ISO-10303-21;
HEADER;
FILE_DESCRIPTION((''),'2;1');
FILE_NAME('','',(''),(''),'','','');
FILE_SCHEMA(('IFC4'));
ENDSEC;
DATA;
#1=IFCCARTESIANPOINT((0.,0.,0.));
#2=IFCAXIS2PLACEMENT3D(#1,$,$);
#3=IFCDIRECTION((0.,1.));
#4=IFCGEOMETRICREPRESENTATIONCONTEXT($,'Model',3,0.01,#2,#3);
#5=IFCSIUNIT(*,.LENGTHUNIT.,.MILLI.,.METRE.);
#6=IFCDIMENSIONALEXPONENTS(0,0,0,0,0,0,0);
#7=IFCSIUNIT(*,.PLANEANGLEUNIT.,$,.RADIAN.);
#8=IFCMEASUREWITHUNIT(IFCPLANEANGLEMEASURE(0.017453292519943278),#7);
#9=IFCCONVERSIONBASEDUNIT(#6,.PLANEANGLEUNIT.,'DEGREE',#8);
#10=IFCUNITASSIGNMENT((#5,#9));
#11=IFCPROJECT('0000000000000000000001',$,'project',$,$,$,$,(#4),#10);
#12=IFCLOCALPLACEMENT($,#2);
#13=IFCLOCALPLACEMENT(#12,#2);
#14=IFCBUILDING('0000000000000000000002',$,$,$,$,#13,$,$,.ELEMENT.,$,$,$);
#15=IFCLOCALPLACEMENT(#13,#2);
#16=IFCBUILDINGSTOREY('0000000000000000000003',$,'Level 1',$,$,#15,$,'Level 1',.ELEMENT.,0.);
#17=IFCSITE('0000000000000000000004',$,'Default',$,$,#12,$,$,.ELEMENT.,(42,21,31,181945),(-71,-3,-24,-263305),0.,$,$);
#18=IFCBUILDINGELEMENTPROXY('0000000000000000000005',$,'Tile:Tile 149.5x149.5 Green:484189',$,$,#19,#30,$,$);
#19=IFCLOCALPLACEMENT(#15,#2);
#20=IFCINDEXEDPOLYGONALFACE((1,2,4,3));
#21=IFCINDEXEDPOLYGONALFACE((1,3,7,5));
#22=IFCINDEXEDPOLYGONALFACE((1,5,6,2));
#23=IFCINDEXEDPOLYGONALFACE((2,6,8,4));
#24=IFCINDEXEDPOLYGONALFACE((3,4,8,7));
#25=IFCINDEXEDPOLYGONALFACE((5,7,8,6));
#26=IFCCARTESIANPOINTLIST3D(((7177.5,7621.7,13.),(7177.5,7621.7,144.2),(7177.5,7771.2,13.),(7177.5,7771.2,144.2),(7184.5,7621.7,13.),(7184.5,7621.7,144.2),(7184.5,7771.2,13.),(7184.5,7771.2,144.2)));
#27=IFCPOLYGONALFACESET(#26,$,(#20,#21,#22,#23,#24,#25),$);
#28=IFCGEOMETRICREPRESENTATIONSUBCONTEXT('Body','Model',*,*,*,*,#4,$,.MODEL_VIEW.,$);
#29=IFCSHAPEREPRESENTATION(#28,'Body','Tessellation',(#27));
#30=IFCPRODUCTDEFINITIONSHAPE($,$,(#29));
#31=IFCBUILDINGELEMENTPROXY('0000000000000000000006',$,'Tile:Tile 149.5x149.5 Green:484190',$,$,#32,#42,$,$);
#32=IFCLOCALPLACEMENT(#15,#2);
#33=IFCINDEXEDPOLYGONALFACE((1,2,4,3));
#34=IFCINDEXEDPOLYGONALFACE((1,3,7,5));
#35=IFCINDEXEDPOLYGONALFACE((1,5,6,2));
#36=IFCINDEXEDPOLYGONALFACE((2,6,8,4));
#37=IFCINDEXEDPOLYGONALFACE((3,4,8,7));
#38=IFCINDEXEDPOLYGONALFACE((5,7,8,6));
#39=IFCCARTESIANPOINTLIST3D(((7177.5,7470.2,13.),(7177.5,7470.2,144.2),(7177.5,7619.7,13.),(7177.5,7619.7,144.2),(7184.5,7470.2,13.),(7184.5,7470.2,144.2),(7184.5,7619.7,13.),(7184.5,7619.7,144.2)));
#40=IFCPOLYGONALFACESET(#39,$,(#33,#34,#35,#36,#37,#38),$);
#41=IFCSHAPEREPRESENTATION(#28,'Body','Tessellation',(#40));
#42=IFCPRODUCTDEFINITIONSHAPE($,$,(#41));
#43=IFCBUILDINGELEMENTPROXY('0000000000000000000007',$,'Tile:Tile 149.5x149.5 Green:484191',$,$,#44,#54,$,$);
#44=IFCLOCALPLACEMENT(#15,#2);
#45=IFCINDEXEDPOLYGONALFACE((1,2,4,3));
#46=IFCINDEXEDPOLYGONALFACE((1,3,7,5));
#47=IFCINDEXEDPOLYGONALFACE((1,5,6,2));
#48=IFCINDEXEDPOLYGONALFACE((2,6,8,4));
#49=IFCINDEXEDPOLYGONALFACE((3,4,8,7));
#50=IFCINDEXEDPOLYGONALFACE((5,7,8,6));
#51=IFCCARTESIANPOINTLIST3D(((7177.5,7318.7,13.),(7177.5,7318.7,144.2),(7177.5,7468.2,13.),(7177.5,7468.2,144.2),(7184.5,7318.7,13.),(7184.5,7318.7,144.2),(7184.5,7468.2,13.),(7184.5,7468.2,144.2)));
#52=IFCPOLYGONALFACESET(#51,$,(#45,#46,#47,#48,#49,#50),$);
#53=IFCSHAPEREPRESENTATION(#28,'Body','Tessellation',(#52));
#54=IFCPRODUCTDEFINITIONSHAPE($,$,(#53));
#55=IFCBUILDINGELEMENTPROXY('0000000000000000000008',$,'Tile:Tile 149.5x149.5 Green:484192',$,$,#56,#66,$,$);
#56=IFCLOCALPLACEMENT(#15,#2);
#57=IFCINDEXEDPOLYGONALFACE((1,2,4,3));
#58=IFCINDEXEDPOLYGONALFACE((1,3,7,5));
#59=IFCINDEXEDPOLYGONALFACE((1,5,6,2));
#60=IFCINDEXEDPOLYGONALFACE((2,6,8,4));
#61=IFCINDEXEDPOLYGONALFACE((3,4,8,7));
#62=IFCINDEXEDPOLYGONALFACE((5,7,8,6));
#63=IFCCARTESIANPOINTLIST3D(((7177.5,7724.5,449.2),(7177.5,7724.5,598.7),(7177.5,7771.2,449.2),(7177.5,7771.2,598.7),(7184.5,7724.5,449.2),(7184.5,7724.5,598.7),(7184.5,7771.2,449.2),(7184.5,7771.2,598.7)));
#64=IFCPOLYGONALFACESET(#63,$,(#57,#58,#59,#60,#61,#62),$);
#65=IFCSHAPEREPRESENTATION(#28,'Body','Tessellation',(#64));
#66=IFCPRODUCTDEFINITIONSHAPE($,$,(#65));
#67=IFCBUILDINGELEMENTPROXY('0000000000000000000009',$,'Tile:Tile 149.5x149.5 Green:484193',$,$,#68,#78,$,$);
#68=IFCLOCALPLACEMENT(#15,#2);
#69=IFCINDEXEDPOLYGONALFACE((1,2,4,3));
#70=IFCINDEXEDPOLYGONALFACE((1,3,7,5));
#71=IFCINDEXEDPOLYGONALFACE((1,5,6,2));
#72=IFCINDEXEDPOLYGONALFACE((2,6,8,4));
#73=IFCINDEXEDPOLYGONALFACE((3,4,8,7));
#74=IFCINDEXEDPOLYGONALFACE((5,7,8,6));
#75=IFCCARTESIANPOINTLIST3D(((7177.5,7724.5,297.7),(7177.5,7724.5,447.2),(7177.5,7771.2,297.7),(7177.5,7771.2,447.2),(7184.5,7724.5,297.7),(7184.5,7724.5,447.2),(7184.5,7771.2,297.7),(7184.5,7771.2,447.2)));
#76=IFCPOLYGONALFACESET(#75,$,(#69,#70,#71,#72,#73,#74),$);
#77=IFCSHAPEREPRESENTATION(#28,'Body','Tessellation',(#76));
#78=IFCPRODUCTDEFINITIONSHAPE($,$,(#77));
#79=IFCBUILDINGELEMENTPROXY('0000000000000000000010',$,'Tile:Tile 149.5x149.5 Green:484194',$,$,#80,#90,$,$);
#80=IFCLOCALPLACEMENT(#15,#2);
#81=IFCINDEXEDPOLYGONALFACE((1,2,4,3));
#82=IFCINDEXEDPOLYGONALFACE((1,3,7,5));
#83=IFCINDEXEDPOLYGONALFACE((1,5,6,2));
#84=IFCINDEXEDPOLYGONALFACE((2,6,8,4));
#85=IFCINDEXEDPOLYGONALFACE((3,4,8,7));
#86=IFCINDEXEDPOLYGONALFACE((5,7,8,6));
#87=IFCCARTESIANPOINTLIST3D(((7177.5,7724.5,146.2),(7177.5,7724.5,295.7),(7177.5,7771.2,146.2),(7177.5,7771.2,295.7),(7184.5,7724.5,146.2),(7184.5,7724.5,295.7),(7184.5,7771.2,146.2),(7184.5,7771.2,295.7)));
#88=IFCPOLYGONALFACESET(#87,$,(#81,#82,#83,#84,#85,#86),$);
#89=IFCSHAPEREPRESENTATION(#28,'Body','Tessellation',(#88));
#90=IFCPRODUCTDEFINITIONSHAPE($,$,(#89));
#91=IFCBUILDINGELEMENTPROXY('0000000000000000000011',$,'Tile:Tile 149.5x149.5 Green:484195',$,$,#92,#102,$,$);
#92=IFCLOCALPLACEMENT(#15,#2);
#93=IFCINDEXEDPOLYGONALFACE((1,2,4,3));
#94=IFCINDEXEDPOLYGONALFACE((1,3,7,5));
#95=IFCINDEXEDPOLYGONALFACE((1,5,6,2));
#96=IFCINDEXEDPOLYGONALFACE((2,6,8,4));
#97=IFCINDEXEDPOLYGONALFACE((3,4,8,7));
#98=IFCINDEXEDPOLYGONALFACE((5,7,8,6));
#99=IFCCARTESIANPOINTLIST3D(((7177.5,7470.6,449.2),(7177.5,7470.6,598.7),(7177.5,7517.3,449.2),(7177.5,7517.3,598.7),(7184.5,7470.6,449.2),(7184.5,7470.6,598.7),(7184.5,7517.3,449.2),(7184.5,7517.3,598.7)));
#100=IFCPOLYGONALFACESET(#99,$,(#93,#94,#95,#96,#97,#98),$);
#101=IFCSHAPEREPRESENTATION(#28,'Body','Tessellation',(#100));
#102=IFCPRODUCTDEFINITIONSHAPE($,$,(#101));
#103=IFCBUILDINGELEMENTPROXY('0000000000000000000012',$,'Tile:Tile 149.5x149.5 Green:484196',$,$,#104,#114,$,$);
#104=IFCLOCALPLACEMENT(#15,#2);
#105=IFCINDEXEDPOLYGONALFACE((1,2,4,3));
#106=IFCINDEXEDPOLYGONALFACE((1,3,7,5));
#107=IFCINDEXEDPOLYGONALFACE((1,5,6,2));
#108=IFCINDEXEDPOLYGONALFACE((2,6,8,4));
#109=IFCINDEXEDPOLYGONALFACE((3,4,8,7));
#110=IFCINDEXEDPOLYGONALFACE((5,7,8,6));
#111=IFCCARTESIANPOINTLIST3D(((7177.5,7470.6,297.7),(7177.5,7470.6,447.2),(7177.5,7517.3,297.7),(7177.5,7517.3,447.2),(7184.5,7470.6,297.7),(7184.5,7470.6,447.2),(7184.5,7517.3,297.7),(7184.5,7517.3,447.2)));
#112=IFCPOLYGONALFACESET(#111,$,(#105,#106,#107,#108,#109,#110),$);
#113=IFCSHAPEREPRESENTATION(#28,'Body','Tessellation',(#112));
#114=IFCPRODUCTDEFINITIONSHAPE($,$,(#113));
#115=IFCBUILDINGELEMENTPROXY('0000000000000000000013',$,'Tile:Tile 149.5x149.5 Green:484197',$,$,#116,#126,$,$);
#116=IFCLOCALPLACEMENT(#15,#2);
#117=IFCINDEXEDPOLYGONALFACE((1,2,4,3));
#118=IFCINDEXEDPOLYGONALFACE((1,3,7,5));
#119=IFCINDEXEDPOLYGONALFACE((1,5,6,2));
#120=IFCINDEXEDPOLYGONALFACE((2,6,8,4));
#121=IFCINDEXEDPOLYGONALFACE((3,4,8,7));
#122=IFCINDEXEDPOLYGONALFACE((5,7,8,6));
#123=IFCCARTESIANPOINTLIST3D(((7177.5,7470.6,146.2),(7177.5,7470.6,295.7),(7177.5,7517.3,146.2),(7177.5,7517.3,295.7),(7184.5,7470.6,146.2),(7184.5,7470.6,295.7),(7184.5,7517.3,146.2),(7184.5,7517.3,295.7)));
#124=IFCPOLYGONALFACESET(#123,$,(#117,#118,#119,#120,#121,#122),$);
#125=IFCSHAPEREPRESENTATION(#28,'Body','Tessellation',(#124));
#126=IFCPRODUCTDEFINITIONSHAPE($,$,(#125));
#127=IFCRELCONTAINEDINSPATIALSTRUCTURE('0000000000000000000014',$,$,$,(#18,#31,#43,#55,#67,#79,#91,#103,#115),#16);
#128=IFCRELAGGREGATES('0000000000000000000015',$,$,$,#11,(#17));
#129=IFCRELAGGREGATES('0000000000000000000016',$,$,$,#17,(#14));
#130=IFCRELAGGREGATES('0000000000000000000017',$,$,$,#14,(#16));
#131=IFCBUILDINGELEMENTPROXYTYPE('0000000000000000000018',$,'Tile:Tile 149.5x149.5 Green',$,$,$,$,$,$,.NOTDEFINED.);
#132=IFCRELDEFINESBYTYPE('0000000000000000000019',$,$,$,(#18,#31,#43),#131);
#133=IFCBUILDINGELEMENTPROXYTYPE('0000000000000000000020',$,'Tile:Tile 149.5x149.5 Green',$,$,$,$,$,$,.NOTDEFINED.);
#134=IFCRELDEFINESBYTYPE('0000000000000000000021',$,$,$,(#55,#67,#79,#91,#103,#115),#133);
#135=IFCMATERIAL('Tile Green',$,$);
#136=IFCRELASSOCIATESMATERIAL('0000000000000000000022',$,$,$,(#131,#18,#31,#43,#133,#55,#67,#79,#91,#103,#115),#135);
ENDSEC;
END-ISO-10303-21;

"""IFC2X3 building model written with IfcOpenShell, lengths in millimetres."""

from ifc_helpers import new_model, entity, si_unit, converted_unit, direction, frame, origin, origin_2d_with_axis, place, context, subcontext, project, spatial, rectangle, extrude, source, transform, mapped, material, type_object, type_shapes, element, save


model = new_model("IFC2X3")

# Units and contexts
model_context = context("Model", 3, precision=0.01, world=origin(), true_north=direction((0.0, 1.0)))
body_context = subcontext(model_context, "Body", "Model", "MODEL_VIEW")
ifc_project = project(units=[si_unit("LENGTHUNIT", "METRE", prefix="MILLI"), converted_unit("PLANEANGLEUNIT", "DEGREE", entity("IfcPlaneAngleMeasure", 0.017453292519943278), si_unit("PLANEANGLEUNIT", "RADIAN"), dimensions=[0, 0, 0, 0, 0, 0, 0])], contexts=[model_context])

# Site, building, storey
site_placement = place(None, origin())
site = spatial("IfcSite", under=ifc_project, at=site_placement, Name="Default", CompositionType="ELEMENT", RefLatitude=(42, 21, 31, 181945), RefLongitude=(-71, -3, -24, -263305), RefElevation=0.0)
building_placement = place(site_placement, origin())
building = spatial("IfcBuilding", under=site, at=building_placement, CompositionType="ELEMENT")
storey_placement = place(building_placement, origin())
storey = spatial("IfcBuildingStorey", under=building, at=storey_placement, Name="Level 1", LongName="Level 1", CompositionType="ELEMENT", Elevation=0.0)

# Building element proxies
ifc_material_1 = material(Name="Tile Green")
building_element_proxy_type_1 = type_object("IfcBuildingElementProxyType", Name="Tile:Tile 149.5x149.5 Green", PredefinedType="NOTDEFINED", material=ifc_material_1)
shared_shape_1 = source(origin(), body_context, "Body", "SweptSolid", [
    extrude(rectangle(XDim=131.2, YDim=149.5, at=origin_2d_with_axis()), frame((-65.6, -74.8, 0.0), z_axis=(0.0, 0.0, 1.0), x_axis=(-1.0, 0.0, 0.0)), (0.0, 0.0, 1.0), 7.0),
])
type_shapes(building_element_proxy_type_1, [shared_shape_1])
for number, where, z_axis, x_axis, name in (
    (1, (7184.5, 7771.2, 144.2), (-1.0, 0.0, 0.0), (0.0, 0.0, 1.0), "Tile:Tile 149.5x149.5 Green:484189"),
    (2, (7184.5, 7619.7, 144.2), (-1.0, 0.0, 0.0), (0.0, 0.0, 1.0), "Tile:Tile 149.5x149.5 Green:484190"),
    (3, (7184.5, 7468.2, 144.2), (-1.0, 0.0, 0.0), (0.0, 0.0, 1.0), "Tile:Tile 149.5x149.5 Green:484191"),
):
    element("IfcBuildingElementProxy", number, at=place(storey_placement, frame(where, z_axis=z_axis, x_axis=x_axis)), inside=storey, type_object=building_element_proxy_type_1, material=ifc_material_1, Name=name, context=body_context, shape_type="MappedRepresentation", body=[
        mapped(shared_shape_1, transform((0.0, 0.0, 0.0), scale=1.0)),
    ])
building_element_proxy_type_2 = type_object("IfcBuildingElementProxyType", Name="Tile:Tile 149.5x149.5 Green", PredefinedType="NOTDEFINED", material=ifc_material_1)
shared_shape_2 = source(origin(), body_context, "Body", "SweptSolid", [
    extrude(rectangle(XDim=46.7, YDim=149.5, at=origin_2d_with_axis()), frame((-23.3, -74.8, 0.0), z_axis=(0.0, 0.0, 1.0), x_axis=(-1.0, 0.0, 0.0)), (0.0, 0.0, 1.0), 7.0),
])
type_shapes(building_element_proxy_type_2, [shared_shape_2])
for number, where, z_axis, x_axis, name in (
    (4, (7184.5, 7771.2, 449.2), (-1.0, 0.0, 0.0), (0.0, 1.0, 0.0), "Tile:Tile 149.5x149.5 Green:484192"),
    (5, (7184.5, 7771.2, 297.7), (-1.0, 0.0, 0.0), (0.0, 1.0, 0.0), "Tile:Tile 149.5x149.5 Green:484193"),
    (6, (7184.5, 7771.2, 146.2), (-1.0, 0.0, 0.0), (0.0, 1.0, 0.0), "Tile:Tile 149.5x149.5 Green:484194"),
    (7, (7184.5, 7517.3, 449.2), (-1.0, 0.0, 0.0), (0.0, 1.0, 0.0), "Tile:Tile 149.5x149.5 Green:484195"),
    (8, (7184.5, 7517.3, 297.7), (-1.0, 0.0, 0.0), (0.0, 1.0, 0.0), "Tile:Tile 149.5x149.5 Green:484196"),
    (9, (7184.5, 7517.3, 146.2), (-1.0, 0.0, 0.0), (0.0, 1.0, 0.0), "Tile:Tile 149.5x149.5 Green:484197"),
):
    element("IfcBuildingElementProxy", number, at=place(storey_placement, frame(where, z_axis=z_axis, x_axis=x_axis)), inside=storey, type_object=building_element_proxy_type_2, material=ifc_material_1, Name=name, context=body_context, shape_type="MappedRepresentation", body=[
        mapped(shared_shape_2, transform((0.0, 0.0, 0.0), scale=1.0)),
    ])

save(model, "model.ifc")
